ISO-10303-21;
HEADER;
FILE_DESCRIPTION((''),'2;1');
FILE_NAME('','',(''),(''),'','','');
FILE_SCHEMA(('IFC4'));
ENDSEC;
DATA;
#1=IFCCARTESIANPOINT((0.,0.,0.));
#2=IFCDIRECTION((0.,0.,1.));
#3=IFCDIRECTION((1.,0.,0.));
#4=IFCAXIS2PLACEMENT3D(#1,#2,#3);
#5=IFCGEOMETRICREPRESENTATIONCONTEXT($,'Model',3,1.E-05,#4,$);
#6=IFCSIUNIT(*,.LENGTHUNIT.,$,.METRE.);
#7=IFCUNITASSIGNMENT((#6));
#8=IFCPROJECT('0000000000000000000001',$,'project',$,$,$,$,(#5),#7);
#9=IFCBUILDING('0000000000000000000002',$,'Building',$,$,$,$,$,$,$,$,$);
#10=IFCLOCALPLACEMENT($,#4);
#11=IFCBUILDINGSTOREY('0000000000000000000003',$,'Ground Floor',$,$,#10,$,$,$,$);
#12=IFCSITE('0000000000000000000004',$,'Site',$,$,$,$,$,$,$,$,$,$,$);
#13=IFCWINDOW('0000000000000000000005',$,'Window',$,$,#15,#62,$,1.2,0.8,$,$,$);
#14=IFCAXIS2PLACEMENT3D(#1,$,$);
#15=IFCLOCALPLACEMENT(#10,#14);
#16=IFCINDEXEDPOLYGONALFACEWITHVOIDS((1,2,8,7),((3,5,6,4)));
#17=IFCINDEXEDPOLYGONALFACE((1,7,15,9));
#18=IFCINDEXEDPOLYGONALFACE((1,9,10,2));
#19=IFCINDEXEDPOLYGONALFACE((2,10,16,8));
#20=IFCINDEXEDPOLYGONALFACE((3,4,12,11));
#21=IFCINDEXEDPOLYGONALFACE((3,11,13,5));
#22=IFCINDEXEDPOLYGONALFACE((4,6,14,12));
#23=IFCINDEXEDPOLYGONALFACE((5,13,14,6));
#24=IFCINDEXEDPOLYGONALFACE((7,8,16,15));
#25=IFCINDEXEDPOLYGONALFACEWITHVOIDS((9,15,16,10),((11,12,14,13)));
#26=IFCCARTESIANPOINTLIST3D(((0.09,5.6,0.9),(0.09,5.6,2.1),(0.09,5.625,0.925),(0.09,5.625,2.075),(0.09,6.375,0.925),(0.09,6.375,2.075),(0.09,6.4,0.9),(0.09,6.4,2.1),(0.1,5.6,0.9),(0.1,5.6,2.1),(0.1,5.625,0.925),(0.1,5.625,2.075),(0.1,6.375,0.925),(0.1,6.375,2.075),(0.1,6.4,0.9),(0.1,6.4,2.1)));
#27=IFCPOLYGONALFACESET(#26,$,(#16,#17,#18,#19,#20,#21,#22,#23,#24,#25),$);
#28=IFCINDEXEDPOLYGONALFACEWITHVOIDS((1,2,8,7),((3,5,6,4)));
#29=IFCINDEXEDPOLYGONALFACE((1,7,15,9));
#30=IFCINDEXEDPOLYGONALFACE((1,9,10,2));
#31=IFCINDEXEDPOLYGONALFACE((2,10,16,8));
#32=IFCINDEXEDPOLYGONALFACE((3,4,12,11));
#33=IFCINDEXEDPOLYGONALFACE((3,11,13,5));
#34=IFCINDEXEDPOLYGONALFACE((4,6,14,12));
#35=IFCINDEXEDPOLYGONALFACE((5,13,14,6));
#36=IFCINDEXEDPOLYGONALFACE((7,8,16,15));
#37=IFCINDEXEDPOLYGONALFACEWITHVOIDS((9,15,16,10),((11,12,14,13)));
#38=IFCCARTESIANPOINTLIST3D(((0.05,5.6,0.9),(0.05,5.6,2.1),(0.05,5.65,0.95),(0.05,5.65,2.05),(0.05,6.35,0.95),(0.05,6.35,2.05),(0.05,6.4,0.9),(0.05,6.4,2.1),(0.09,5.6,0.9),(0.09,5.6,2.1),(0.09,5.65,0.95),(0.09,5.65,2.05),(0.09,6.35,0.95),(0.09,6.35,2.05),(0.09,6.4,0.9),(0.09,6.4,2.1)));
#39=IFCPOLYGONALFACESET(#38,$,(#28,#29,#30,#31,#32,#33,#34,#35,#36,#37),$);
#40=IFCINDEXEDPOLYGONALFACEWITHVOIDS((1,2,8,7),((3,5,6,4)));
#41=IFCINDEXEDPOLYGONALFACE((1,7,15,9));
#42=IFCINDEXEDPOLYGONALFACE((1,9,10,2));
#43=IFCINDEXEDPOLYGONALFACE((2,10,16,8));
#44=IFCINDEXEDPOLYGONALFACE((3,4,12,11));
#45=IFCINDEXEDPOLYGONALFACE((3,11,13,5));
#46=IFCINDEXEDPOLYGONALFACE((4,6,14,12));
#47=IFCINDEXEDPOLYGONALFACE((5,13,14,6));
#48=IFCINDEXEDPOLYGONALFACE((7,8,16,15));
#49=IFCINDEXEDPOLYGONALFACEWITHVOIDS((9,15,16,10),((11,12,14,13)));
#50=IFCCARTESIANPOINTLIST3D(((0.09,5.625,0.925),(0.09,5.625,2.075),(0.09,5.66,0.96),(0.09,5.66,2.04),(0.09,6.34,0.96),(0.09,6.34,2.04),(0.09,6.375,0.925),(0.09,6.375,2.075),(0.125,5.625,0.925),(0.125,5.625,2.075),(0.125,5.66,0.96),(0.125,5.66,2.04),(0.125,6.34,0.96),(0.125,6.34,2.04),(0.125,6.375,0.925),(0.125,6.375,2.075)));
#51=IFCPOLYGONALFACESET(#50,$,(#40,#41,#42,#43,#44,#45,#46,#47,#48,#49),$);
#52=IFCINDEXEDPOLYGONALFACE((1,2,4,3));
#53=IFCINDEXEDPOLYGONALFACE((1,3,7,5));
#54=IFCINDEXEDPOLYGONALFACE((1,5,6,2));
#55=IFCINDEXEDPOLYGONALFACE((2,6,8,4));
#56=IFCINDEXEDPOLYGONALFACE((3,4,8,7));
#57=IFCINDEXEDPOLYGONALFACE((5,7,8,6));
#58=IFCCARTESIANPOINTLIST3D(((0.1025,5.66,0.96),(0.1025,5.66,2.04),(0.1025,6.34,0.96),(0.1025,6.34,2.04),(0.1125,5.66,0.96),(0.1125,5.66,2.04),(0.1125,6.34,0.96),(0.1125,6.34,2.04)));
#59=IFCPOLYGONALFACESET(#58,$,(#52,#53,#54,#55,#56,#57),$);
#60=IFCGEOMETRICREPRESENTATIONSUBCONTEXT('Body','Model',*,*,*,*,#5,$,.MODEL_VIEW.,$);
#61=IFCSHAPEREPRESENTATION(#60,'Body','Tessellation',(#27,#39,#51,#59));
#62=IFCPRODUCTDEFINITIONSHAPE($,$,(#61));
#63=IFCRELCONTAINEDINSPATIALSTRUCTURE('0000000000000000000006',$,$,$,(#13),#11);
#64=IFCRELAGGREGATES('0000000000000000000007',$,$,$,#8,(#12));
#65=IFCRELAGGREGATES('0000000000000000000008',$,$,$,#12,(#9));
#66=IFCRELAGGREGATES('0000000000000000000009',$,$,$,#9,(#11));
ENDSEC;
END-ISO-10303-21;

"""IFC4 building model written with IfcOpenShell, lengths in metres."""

from ifc_helpers import new_model, si_unit, frame, origin_with_axes, place, context, subcontext, project, spatial, line, indexed_curve, outline, extrude, element, save


model = new_model("IFC4")

# Units and contexts
model_context = context("Model", 3, precision=1e-05, world=origin_with_axes())
body_context = subcontext(model_context, "Body", "Model", "MODEL_VIEW")
ifc_project = project(units=[si_unit("LENGTHUNIT", "METRE")], contexts=[model_context])

# Site, building, storey
site = spatial("IfcSite", under=ifc_project, Name="Site")
building = spatial("IfcBuilding", under=site, Name="Building")
storey_placement = place(None, origin_with_axes())
storey = spatial("IfcBuildingStorey", under=building, at=storey_placement, Name="Ground Floor")

# Window
window_1_placement = place(storey_placement, frame((0.0, 6.4, 0.9), z_axis=(0.0, 0.0, 1.0), x_axis=(0.0, -1.0, 0.0)))
element("IfcWindow", 1, at=window_1_placement, inside=storey, Name="Window", OverallHeight=1.2, OverallWidth=0.8, context=body_context, shape_type="SweptSolid", body=[
    extrude(outline(indexed_curve([(0.0, 0.0), (0.8, 0.0), (0.8, 1.2), (0.0, 1.2)], segments=[line(1, 2, 3, 4, 1)]), holes=[indexed_curve([(0.025, 0.025), (0.775, 0.025), (0.775, 1.175), (0.025, 1.175)], segments=[line(1, 2, 3, 4, 1)])]), frame((0.0, 0.09, 0.0), z_axis=(0.0, -1.0, 0.0), x_axis=(1.0, 0.0, 0.0)), (0.0, 0.0, -1.0), 0.01),
    extrude(outline(indexed_curve([(0.0, 0.0), (0.8, 0.0), (0.8, 1.2), (0.0, 1.2)], segments=[line(1, 2, 3, 4, 1)]), holes=[indexed_curve([(0.05, 0.05), (0.75, 0.05), (0.75, 1.15), (0.05, 1.15)], segments=[line(1, 2, 3, 4, 1)])]), frame((0.0, 0.05, 0.0), z_axis=(0.0, -1.0, 0.0), x_axis=(1.0, 0.0, 0.0)), (0.0, 0.0, -1.0), 0.04),
    extrude(outline(indexed_curve([(0.0, 0.0), (0.75, 0.0), (0.75, 1.15), (0.0, 1.15)], segments=[line(1, 2, 3, 4, 1)]), holes=[indexed_curve([(0.035, 0.035), (0.715, 0.035), (0.715, 1.115), (0.035, 1.115)], segments=[line(1, 2, 3, 4, 1)])]), frame((0.025, 0.09, 0.025), z_axis=(0.0, -1.0, 0.0), x_axis=(1.0, 0.0, 0.0)), (0.0, 0.0, -1.0), 0.035),
    extrude(outline(indexed_curve([(0.035, 0.035), (0.715, 0.035), (0.715, 1.115), (0.035, 1.115)], segments=[line(1, 2, 3, 4, 1)])), frame((0.025, 0.1025, 0.025), z_axis=(0.0, -1.0, 0.0), x_axis=(1.0, 0.0, 0.0)), (0.0, 0.0, -1.0), 0.01),
])

save(model, "model.ifc")
